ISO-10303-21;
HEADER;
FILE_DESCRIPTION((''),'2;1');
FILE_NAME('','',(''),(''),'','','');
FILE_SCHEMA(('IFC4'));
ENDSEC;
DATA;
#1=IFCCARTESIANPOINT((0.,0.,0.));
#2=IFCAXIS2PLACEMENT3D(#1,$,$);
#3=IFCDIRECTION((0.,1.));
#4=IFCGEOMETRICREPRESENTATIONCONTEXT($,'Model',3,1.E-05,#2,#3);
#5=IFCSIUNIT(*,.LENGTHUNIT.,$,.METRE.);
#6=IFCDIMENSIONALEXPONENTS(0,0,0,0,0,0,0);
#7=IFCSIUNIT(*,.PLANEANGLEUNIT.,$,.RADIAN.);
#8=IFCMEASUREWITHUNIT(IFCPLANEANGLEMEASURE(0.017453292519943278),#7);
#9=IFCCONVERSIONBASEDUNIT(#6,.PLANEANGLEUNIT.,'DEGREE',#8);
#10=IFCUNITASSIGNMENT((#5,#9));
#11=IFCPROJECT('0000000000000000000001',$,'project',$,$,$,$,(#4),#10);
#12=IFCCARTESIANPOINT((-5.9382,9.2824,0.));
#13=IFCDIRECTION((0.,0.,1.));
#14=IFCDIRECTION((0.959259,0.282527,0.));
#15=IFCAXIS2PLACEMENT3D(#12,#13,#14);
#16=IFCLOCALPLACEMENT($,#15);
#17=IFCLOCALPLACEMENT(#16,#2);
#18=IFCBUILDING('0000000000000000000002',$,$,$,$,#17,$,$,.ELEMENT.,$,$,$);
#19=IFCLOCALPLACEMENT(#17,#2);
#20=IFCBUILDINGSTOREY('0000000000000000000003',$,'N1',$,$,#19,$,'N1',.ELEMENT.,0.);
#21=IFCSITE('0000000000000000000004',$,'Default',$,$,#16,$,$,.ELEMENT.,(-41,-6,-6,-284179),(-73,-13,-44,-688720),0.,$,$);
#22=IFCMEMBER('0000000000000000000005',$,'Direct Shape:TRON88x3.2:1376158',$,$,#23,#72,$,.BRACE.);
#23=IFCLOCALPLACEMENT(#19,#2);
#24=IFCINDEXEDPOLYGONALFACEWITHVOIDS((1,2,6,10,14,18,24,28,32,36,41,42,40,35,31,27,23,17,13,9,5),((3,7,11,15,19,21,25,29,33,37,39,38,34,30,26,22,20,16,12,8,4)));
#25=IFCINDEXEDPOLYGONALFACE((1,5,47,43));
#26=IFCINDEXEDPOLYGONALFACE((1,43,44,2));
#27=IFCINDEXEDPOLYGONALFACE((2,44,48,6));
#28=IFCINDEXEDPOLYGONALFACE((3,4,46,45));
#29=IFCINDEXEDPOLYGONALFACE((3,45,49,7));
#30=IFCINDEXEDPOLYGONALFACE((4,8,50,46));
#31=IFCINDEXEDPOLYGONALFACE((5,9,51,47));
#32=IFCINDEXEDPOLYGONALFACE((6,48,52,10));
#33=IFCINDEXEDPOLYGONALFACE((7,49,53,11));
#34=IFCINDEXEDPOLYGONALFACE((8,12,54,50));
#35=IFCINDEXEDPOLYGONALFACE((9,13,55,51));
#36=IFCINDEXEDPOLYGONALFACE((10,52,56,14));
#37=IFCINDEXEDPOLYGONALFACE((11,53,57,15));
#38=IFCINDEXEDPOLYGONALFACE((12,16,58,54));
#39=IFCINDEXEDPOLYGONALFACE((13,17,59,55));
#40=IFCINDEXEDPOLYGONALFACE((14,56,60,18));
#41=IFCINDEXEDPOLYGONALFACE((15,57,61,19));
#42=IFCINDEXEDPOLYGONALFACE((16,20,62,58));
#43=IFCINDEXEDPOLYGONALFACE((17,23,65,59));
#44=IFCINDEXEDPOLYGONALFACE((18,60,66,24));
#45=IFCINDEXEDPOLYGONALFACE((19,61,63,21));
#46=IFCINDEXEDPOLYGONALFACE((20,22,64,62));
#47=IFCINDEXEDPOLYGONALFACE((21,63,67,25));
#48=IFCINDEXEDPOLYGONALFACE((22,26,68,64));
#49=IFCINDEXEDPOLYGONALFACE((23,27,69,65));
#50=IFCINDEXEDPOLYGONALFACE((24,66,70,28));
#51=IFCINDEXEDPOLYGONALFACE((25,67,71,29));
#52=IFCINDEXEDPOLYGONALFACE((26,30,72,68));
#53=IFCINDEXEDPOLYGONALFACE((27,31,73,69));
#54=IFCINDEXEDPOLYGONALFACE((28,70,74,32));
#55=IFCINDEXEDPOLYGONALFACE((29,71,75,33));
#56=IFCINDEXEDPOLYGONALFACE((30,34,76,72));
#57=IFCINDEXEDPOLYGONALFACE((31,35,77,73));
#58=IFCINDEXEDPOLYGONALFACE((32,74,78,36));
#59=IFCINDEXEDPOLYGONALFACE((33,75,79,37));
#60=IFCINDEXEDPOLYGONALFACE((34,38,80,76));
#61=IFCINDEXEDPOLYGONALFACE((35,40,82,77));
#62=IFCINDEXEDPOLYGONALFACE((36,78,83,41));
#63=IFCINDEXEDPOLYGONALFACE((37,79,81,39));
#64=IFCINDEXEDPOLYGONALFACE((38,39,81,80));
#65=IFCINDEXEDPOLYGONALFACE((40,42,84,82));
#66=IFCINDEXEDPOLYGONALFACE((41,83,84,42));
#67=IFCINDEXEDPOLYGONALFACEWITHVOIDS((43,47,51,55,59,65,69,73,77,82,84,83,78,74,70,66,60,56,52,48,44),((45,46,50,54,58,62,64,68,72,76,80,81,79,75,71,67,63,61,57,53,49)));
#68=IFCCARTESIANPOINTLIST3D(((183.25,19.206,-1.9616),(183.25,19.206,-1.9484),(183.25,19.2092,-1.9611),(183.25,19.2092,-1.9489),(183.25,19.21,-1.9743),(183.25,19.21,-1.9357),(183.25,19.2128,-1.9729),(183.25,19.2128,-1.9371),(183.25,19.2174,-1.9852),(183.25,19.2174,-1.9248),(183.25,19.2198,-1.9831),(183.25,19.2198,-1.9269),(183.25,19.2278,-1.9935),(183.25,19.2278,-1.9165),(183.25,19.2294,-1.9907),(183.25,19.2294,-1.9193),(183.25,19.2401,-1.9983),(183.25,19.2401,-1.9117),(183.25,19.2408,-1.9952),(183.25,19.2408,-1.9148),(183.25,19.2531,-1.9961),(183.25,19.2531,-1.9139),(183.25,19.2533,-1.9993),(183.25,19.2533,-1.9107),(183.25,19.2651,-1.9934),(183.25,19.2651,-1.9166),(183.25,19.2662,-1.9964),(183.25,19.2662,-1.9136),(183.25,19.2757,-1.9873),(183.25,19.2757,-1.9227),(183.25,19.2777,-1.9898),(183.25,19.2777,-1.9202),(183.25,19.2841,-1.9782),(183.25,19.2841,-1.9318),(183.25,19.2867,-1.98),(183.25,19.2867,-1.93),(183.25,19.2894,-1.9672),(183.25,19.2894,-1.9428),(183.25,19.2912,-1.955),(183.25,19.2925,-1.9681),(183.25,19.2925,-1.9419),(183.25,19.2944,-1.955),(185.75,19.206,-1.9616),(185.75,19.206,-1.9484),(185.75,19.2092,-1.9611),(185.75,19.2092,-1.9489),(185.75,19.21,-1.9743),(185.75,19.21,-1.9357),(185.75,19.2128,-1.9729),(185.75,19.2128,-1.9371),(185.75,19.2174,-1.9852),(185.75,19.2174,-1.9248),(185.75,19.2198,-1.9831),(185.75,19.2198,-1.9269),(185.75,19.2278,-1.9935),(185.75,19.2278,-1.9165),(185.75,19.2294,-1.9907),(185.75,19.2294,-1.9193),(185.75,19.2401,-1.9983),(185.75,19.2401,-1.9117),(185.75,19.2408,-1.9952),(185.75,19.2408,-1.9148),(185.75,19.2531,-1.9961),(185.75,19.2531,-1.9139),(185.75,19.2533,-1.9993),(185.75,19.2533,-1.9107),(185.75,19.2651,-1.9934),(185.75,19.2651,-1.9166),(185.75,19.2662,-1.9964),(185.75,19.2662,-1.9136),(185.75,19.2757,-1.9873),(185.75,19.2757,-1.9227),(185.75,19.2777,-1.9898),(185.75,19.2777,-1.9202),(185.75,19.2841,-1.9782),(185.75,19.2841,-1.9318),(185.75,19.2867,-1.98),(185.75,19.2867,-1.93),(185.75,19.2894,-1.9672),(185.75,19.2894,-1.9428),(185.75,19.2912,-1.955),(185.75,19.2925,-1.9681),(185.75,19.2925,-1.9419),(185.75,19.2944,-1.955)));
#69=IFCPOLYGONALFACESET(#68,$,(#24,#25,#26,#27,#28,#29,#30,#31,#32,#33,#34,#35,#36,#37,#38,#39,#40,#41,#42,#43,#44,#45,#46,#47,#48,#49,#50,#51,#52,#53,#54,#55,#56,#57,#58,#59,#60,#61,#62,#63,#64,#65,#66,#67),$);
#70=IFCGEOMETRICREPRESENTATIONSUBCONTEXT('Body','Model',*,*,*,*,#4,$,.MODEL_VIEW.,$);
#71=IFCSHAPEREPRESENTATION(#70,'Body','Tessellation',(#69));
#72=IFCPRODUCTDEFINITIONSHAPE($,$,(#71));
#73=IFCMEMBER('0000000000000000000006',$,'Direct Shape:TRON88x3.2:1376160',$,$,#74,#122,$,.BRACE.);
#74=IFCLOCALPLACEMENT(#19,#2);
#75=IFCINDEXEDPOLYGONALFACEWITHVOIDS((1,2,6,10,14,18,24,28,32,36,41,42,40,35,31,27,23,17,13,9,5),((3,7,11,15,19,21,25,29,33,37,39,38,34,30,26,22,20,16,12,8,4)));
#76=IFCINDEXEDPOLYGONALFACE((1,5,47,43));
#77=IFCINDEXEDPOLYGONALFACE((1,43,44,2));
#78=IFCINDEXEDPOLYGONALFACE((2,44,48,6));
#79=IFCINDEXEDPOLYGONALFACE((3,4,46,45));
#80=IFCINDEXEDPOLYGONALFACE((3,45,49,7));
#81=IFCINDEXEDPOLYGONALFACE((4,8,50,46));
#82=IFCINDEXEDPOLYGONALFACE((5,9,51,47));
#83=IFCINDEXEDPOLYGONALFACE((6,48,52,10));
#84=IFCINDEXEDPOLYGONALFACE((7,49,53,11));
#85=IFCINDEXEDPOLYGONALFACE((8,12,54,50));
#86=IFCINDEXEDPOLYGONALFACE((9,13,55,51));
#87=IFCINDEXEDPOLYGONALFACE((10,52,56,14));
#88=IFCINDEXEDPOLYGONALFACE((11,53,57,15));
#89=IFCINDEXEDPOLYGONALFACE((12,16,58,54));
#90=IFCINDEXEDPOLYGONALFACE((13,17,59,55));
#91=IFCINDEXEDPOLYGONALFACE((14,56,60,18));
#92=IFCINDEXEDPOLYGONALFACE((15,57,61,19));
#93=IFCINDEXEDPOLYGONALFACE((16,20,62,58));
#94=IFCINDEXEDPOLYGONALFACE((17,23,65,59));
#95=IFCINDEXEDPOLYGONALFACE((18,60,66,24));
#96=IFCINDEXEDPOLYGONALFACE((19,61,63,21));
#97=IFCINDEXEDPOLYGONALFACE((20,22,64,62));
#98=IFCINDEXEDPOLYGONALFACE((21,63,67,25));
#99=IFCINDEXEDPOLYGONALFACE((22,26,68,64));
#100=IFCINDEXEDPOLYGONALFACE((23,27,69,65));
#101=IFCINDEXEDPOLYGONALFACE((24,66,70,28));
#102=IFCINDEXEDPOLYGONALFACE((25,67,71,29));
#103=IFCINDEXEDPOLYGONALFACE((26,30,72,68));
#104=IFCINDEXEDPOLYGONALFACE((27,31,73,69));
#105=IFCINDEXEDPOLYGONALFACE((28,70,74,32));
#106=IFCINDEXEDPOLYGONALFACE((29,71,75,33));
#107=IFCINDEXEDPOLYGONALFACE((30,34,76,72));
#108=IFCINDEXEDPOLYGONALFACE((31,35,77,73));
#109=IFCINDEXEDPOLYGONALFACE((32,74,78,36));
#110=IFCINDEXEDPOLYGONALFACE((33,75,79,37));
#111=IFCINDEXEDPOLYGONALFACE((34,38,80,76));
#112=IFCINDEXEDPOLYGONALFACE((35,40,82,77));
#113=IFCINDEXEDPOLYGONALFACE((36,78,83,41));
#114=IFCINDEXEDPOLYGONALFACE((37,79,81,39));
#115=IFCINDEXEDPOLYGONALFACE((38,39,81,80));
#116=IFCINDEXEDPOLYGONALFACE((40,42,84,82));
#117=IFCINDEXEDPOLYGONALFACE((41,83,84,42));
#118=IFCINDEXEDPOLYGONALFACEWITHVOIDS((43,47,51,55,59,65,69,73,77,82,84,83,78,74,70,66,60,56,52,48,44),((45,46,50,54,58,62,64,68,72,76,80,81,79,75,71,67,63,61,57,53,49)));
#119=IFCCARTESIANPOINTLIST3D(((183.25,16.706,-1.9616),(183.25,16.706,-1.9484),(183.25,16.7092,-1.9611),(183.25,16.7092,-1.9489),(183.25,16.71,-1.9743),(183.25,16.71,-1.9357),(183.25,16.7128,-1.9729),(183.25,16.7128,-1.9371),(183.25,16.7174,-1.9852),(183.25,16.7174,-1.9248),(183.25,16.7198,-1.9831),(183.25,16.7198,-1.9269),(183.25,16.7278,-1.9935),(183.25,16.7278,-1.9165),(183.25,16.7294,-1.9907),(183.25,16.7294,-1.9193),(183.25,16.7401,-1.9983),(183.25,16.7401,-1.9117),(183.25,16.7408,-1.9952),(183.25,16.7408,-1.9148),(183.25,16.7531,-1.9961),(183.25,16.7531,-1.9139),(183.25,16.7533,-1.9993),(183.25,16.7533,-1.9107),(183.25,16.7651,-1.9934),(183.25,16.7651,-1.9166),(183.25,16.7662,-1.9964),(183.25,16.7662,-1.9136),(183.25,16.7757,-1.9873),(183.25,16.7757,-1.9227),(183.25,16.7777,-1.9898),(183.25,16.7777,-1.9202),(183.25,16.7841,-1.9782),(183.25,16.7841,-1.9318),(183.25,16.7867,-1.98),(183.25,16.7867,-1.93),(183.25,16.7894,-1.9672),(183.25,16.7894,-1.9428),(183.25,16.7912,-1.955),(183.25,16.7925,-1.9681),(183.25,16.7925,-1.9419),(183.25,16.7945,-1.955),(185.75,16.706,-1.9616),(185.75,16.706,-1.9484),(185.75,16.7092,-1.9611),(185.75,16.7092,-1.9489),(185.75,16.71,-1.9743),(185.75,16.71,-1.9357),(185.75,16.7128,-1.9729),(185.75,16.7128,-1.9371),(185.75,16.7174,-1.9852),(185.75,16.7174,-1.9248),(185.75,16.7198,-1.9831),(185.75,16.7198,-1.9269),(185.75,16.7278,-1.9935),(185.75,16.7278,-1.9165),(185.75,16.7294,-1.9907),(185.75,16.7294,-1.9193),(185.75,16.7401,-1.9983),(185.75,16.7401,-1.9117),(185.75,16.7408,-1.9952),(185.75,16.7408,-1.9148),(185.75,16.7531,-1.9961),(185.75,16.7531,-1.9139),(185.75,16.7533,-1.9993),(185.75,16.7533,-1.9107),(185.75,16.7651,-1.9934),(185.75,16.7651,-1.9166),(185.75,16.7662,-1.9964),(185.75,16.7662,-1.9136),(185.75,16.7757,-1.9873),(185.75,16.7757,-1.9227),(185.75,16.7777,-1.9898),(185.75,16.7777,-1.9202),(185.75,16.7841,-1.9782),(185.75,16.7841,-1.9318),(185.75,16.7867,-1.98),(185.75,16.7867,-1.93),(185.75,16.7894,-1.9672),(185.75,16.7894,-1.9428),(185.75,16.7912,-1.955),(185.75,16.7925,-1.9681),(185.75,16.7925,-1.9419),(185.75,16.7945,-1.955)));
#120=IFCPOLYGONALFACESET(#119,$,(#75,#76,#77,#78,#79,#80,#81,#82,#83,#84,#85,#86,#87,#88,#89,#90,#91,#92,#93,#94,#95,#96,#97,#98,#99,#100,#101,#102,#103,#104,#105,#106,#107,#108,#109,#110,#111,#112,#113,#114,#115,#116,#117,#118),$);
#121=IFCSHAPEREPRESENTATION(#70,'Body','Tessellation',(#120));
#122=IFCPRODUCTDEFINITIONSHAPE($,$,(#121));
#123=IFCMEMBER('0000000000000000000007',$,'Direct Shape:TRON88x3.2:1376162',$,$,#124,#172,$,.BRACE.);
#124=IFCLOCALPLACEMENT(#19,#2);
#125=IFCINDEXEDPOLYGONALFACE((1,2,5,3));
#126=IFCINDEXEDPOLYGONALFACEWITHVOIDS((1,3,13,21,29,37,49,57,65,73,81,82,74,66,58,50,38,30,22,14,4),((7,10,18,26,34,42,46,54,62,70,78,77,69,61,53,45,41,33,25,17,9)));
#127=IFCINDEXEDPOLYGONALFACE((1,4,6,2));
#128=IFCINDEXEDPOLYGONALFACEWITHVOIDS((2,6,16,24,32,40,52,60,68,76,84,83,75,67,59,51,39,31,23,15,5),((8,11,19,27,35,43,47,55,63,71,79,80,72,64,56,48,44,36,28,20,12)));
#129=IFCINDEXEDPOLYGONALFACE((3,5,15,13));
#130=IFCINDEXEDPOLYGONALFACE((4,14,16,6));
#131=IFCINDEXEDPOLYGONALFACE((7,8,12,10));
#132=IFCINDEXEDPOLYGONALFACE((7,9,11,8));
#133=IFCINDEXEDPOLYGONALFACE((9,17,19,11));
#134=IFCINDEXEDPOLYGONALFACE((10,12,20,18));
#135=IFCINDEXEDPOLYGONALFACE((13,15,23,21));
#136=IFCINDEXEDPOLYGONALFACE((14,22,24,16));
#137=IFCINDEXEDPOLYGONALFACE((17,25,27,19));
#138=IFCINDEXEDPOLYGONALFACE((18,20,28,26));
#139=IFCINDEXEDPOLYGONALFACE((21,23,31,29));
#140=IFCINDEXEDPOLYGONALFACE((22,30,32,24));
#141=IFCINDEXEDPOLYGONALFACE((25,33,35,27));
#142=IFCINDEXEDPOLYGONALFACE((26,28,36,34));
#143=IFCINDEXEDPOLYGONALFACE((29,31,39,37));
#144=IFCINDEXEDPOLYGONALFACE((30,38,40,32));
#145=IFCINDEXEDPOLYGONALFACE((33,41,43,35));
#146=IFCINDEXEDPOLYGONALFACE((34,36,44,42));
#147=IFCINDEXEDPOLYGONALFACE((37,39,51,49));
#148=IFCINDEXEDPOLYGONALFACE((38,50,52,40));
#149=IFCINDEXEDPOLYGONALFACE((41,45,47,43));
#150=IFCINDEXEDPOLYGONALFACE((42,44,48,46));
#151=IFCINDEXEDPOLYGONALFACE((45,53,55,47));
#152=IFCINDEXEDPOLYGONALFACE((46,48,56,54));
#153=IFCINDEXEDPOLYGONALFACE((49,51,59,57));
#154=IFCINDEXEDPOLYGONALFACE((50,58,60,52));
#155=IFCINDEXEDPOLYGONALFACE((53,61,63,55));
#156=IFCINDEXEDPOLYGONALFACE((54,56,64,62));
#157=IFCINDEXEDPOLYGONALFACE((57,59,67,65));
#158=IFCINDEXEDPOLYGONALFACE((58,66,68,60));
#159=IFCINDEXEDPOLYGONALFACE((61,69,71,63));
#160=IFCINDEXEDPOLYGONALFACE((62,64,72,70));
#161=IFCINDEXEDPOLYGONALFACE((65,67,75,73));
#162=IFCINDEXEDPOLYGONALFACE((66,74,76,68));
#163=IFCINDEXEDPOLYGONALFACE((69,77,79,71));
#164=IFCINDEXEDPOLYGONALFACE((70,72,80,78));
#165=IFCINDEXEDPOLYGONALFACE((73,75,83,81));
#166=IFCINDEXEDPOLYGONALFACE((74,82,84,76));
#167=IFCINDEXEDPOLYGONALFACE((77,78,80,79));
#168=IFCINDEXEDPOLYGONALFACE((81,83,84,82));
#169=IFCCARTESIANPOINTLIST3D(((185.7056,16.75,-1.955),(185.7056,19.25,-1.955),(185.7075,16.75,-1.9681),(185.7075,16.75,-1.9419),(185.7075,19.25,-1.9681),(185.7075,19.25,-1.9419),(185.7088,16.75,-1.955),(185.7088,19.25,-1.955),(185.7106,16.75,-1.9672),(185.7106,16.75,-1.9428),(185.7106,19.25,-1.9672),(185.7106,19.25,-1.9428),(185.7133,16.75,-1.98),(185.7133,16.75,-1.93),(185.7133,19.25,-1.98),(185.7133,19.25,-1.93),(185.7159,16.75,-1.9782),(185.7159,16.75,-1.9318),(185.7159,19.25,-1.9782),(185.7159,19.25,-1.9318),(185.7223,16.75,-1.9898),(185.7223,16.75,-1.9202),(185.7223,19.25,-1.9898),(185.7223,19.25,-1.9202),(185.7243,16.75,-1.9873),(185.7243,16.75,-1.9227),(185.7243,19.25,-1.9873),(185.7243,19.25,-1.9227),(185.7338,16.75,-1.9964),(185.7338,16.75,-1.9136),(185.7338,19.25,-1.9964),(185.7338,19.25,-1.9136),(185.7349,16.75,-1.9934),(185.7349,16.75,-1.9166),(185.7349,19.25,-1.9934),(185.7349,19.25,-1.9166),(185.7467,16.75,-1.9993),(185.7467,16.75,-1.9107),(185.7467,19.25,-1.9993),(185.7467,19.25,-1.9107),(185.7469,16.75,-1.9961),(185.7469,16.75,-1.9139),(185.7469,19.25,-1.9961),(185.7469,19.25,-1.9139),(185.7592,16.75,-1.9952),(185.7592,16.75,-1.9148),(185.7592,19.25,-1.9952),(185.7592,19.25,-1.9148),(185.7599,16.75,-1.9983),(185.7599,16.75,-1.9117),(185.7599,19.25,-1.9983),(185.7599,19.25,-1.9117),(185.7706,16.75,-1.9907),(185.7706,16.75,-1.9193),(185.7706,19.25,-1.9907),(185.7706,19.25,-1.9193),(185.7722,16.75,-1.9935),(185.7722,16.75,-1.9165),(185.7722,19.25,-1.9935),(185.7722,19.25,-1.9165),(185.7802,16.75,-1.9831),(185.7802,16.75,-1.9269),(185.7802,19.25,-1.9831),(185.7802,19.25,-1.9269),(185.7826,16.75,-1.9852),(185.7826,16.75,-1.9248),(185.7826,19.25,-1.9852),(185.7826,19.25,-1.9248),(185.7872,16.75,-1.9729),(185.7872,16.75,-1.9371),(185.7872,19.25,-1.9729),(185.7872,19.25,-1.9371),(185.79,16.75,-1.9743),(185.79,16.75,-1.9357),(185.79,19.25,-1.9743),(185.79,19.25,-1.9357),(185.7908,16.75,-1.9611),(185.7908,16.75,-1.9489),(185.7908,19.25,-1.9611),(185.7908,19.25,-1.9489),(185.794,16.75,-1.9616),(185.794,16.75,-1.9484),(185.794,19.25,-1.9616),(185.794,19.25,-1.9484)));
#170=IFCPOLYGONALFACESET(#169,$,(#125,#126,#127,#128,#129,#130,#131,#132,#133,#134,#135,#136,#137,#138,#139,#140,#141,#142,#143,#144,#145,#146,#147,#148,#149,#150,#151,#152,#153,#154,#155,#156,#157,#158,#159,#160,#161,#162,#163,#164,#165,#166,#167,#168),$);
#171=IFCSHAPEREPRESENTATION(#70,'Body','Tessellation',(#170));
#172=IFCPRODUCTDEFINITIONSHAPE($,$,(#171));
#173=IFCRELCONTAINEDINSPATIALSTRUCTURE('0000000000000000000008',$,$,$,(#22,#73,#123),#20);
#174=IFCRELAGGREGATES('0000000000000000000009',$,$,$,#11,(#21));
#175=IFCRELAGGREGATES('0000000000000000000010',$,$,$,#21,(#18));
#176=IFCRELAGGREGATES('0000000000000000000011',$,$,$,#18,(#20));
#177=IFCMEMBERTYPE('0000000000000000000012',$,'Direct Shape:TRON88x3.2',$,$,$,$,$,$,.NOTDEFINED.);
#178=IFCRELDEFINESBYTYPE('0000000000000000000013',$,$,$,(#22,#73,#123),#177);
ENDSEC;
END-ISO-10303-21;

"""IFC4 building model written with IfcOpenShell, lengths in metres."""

from ifc_helpers import new_model, entity, si_unit, converted_unit, direction, frame, frame_2d, origin, place, context, subcontext, project, spatial, hollow_circle, extrude, type_object, element, save


model = new_model("IFC4")

# Units and contexts
model_context = context("Model", 3, precision=1e-05, world=origin(), true_north=direction((0.0, 1.0)))
body_context = subcontext(model_context, "Body", "Model", "MODEL_VIEW")
ifc_project = project(units=[si_unit("LENGTHUNIT", "METRE"), converted_unit("PLANEANGLEUNIT", "DEGREE", entity("IfcPlaneAngleMeasure", 0.017453292519943278), si_unit("PLANEANGLEUNIT", "RADIAN"), dimensions=[0, 0, 0, 0, 0, 0, 0])], contexts=[model_context])

# Site, building, storey
site_placement = place(None, frame((-5.9382, 9.2824, 0.0), z_axis=(0.0, 0.0, 1.0), x_axis=(0.959259, 0.282527, 0.0)))
site = spatial("IfcSite", under=ifc_project, at=site_placement, Name="Default", CompositionType="ELEMENT", RefLatitude=(-41, -6, -6, -284179), RefLongitude=(-73, -13, -44, -688720), RefElevation=0.0)
building_placement = place(site_placement, origin())
building = spatial("IfcBuilding", under=site, at=building_placement, CompositionType="ELEMENT")
storey_placement = place(building_placement, origin())
storey = spatial("IfcBuildingStorey", under=building, at=storey_placement, Name="N1", LongName="N1", CompositionType="ELEMENT", Elevation=0.0)

# Members
member_type_1 = type_object("IfcMemberType", Name="Direct Shape:TRON88x3.2", PredefinedType="NOTDEFINED")
member_1_placement = place(storey_placement, origin())
element("IfcMember", 1, at=member_1_placement, inside=storey, type_object=member_type_1, Name="Direct Shape:TRON88x3.2:1376158", PredefinedType="BRACE", context=body_context, shape_type="SweptSolid", body=[
    extrude(hollow_circle(Radius=0.0445, WallThickness=0.0032, at=frame_2d((0.0, 0.0), x_axis=(1.0, 0.0))), frame((183.25, 19.25, -1.955), z_axis=(1.0, 0.0, 0.0), x_axis=(0.0, 1.0, 0.0)), (0.0, 0.0, 1.0), 2.5),
])
member_2_placement = place(storey_placement, origin())
element("IfcMember", 2, at=member_2_placement, inside=storey, type_object=member_type_1, Name="Direct Shape:TRON88x3.2:1376160", PredefinedType="BRACE", context=body_context, shape_type="SweptSolid", body=[
    extrude(hollow_circle(Radius=0.0445, WallThickness=0.0032, at=frame_2d((0.0, 0.0), x_axis=(1.0, 0.0))), frame((183.25, 16.75, -1.955), z_axis=(1.0, 0.0, 0.0), x_axis=(0.0, 1.0, 0.0)), (0.0, 0.0, 1.0), 2.5),
])
member_3_placement = place(storey_placement, origin())
element("IfcMember", 3, at=member_3_placement, inside=storey, type_object=member_type_1, Name="Direct Shape:TRON88x3.2:1376162", PredefinedType="BRACE", context=body_context, shape_type="SweptSolid", body=[
    extrude(hollow_circle(Radius=0.0445, WallThickness=0.0032, at=frame_2d((0.0, 0.0), x_axis=(1.0, 0.0))), frame((185.75, 16.75, -1.955), z_axis=(0.0, 1.0, 0.0), x_axis=(-1.0, 0.0, 0.0)), (0.0, 0.0, 1.0), 2.5),
])

save(model, "model.ifc")
